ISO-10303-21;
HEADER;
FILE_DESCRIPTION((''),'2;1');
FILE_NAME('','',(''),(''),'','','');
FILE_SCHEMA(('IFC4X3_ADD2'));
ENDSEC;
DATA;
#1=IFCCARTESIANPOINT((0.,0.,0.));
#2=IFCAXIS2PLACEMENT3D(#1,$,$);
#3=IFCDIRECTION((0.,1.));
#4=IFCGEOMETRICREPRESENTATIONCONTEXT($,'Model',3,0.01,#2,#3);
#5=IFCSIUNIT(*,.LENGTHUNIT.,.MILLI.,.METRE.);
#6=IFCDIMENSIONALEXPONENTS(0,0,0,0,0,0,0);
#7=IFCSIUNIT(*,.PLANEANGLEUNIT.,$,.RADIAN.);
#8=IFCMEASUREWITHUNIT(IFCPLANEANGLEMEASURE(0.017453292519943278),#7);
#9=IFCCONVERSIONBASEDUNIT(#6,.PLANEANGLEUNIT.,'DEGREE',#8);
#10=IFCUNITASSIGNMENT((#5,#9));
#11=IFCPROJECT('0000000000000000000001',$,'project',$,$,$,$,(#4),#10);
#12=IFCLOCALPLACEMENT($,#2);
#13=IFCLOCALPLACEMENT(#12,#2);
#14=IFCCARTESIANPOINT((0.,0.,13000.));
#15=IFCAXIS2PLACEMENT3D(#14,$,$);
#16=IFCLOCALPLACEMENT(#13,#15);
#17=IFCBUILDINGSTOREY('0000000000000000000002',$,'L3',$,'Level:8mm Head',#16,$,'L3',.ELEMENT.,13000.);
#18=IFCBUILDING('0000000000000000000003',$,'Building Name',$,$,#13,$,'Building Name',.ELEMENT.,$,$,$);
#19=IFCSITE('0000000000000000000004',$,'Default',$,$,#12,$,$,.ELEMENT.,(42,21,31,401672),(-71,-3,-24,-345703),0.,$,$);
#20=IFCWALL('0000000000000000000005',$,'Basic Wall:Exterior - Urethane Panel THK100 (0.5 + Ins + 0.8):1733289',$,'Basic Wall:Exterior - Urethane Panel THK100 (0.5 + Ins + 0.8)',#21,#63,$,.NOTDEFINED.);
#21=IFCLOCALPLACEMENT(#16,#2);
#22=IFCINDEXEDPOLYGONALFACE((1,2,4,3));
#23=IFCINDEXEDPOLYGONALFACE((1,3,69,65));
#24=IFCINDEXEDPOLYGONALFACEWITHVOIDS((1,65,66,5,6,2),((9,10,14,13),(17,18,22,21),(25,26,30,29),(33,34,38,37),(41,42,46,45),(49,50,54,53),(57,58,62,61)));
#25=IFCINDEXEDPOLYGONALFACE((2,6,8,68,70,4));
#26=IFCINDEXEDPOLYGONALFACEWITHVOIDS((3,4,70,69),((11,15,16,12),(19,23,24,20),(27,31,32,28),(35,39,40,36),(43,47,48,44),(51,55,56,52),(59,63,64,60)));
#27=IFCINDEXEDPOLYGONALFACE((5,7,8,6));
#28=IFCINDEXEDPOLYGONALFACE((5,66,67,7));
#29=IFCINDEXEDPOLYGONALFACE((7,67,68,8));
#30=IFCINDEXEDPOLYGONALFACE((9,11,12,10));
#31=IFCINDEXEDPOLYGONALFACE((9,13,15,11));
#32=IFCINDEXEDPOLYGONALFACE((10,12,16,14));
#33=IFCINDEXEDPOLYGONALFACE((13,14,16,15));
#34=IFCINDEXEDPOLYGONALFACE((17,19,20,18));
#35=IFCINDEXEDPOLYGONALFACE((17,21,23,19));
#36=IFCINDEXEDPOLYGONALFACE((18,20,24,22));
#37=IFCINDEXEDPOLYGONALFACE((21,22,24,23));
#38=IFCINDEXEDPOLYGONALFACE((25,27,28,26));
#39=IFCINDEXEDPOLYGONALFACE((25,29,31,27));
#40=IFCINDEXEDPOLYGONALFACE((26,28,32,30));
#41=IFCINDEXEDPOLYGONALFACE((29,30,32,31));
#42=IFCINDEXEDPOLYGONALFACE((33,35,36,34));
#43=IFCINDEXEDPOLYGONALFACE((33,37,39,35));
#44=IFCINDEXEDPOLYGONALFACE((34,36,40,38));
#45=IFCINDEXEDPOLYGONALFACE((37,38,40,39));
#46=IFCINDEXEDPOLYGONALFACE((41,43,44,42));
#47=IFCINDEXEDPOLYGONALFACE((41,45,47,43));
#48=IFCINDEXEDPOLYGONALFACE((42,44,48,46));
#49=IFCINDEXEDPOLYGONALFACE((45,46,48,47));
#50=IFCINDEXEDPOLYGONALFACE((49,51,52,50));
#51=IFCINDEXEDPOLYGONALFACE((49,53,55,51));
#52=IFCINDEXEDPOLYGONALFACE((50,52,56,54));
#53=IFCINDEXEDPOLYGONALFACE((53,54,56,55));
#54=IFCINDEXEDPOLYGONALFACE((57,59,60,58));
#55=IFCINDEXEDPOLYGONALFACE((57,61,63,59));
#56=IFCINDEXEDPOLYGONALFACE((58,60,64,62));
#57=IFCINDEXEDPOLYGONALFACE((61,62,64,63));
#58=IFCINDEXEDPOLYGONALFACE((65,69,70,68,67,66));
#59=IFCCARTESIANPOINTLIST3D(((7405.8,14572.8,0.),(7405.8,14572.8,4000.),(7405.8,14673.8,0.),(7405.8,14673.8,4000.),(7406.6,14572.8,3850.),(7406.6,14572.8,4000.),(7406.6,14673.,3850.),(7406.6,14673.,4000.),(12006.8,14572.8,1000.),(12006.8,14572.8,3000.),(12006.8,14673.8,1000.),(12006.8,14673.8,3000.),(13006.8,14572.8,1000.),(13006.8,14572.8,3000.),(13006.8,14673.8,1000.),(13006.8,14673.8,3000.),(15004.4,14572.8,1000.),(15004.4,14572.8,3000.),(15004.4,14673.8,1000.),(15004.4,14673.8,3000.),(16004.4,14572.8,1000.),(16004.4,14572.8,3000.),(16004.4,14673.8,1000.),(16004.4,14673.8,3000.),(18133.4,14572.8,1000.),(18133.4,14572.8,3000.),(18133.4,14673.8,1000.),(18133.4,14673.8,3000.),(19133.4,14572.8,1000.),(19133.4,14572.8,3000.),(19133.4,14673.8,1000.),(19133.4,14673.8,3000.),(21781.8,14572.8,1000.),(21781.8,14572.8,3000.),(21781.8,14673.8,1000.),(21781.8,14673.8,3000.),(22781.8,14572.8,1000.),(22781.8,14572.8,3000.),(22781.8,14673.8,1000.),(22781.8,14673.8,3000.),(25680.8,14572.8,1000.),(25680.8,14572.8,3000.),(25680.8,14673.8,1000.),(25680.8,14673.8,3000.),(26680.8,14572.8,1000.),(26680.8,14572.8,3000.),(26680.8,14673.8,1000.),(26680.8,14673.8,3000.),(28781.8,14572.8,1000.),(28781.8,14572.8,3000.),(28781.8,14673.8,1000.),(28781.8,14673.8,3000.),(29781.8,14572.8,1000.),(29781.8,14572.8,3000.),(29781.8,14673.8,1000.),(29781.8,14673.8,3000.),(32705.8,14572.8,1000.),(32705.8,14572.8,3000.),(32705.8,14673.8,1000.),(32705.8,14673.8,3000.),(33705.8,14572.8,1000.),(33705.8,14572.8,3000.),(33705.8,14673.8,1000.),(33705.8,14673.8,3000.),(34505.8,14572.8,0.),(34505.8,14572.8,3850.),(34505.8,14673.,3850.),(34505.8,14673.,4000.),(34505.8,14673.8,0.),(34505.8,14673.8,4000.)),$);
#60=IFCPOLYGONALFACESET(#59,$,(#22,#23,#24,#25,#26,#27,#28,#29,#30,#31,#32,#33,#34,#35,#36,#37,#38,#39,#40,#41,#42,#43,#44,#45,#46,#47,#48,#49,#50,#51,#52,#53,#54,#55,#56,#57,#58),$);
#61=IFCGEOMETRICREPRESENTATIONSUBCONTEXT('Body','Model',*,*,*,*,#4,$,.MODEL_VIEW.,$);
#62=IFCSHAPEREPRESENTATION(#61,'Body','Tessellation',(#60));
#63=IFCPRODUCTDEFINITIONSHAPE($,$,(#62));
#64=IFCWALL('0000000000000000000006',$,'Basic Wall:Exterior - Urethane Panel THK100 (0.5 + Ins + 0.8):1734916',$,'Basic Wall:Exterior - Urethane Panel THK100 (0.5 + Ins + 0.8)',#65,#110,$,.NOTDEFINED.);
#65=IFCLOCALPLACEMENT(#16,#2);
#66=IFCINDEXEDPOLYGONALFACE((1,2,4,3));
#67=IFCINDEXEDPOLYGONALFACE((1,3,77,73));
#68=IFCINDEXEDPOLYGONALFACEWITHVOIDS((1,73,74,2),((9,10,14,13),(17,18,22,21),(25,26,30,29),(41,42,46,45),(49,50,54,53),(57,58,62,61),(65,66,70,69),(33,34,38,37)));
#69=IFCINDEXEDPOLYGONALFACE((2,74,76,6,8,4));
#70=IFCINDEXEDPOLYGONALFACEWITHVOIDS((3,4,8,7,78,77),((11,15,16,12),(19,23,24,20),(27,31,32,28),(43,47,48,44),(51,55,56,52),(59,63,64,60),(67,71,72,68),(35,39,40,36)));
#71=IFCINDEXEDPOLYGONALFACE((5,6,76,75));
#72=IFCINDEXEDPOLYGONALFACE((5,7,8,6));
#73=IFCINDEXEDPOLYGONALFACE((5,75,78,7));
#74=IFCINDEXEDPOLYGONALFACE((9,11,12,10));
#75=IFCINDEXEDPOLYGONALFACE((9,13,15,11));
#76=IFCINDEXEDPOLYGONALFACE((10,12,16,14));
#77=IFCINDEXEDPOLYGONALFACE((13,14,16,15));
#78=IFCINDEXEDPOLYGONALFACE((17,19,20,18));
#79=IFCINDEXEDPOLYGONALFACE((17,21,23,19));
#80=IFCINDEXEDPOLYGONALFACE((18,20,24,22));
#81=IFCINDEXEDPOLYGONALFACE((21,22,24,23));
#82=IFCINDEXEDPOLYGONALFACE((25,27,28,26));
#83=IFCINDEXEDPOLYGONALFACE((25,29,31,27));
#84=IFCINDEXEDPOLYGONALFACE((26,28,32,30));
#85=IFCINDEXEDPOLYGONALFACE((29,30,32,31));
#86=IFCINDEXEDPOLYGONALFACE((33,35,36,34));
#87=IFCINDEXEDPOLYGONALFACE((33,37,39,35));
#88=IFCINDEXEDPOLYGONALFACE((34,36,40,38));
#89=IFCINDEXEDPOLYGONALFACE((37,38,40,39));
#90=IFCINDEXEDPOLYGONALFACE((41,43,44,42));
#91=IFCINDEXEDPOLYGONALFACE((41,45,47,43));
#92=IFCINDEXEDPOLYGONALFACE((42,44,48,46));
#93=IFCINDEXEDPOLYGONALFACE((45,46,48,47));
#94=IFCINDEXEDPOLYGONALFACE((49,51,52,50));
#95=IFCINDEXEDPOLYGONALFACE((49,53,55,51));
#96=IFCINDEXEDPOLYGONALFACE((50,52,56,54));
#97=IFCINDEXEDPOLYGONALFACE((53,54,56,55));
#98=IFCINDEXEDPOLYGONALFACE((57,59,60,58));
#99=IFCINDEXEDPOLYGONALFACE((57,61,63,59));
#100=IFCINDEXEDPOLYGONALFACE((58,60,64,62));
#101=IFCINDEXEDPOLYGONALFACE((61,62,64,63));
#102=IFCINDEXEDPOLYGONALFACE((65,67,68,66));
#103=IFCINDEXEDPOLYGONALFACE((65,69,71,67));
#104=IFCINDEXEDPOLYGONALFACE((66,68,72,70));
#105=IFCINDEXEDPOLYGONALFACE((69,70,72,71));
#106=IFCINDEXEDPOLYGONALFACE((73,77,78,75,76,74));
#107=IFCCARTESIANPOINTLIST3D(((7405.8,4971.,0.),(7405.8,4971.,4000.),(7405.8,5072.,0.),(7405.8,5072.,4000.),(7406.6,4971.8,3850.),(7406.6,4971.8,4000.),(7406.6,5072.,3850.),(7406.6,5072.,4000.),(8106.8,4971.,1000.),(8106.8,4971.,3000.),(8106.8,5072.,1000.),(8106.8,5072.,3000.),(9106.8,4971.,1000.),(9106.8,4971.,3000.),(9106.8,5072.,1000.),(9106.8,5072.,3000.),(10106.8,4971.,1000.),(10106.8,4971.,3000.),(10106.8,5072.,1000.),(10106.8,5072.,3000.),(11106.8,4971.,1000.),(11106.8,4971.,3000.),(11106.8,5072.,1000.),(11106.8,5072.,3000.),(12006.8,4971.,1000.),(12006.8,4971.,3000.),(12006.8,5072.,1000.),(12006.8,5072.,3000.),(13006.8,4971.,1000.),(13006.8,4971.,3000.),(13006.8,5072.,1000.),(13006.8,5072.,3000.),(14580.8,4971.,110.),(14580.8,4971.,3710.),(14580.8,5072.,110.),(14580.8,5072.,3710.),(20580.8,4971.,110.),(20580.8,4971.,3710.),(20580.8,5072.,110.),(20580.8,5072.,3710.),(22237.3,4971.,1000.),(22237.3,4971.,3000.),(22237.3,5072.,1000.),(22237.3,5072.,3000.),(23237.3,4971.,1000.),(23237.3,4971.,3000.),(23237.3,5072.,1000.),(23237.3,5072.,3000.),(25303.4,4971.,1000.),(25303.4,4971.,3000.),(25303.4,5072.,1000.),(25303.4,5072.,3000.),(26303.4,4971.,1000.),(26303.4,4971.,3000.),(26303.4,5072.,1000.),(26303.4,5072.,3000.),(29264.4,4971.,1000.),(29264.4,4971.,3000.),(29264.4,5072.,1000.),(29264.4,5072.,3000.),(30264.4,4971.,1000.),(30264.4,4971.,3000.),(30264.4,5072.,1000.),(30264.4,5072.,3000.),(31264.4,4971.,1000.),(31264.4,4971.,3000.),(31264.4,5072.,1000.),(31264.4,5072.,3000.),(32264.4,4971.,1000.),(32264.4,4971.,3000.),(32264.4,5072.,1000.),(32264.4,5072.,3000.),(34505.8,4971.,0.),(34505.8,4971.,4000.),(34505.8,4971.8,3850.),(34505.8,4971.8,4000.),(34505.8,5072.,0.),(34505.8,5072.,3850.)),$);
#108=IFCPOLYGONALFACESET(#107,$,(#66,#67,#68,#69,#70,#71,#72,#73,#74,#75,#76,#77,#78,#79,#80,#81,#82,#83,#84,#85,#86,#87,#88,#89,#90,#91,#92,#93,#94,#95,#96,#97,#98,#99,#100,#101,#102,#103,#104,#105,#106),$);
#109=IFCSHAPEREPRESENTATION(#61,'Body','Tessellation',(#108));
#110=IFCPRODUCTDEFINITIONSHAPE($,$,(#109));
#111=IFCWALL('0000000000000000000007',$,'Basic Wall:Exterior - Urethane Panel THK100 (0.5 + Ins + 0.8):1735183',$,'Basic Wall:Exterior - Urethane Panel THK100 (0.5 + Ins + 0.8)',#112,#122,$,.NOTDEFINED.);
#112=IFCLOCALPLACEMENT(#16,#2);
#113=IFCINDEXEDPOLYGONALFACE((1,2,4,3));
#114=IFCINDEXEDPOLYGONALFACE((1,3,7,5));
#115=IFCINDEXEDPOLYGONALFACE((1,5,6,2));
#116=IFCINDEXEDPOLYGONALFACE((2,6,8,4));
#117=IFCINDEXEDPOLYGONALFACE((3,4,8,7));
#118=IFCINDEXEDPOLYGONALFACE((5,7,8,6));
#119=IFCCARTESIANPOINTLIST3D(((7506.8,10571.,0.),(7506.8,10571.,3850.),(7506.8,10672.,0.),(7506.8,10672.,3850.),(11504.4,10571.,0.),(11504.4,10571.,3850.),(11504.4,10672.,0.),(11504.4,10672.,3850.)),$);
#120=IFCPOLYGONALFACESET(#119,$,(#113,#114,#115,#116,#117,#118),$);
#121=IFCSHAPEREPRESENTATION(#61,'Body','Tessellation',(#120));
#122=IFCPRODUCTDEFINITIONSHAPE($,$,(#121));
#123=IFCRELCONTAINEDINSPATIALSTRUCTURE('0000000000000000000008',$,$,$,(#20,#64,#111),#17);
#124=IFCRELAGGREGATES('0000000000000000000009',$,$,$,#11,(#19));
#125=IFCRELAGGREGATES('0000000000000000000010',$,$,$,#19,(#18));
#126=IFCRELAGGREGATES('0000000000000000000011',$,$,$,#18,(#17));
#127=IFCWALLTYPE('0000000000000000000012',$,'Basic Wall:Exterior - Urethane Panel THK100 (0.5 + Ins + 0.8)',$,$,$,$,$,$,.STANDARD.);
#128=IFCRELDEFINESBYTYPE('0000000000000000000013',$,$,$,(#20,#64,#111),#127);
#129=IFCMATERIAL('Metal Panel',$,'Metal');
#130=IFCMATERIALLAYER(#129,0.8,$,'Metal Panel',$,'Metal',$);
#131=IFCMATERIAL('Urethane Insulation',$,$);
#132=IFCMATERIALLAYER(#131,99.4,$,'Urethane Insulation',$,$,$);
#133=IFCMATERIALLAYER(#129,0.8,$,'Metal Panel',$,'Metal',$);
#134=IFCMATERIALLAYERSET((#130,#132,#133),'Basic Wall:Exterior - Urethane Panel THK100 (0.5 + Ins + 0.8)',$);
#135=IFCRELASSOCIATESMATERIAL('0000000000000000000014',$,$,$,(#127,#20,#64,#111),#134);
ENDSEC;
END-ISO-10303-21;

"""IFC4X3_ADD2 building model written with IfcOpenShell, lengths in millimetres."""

from ifc_helpers import new_model, entity, si_unit, converted_unit, direction, frame, frame_2d, origin, place, context, subcontext, project, spatial, polyline, rectangle, extrude, clip, bounded_halfspace, material, layer, layer_set, type_object, element, save


model = new_model("IFC4X3_ADD2")

# Units and contexts
model_context = context("Model", 3, precision=0.01, world=origin(), true_north=direction((0.0, 1.0)))
body_context = subcontext(model_context, "Body", "Model", "MODEL_VIEW")
ifc_project = project(units=[si_unit("LENGTHUNIT", "METRE", prefix="MILLI"), converted_unit("PLANEANGLEUNIT", "DEGREE", entity("IfcPlaneAngleMeasure", 0.017453292519943278), si_unit("PLANEANGLEUNIT", "RADIAN"), dimensions=[0, 0, 0, 0, 0, 0, 0])], contexts=[model_context])

# Site, building, storey
site_placement = place(None, origin())
site = spatial("IfcSite", under=ifc_project, at=site_placement, Name="Default", CompositionType="ELEMENT", RefLatitude=(42, 21, 31, 401672), RefLongitude=(-71, -3, -24, -345703), RefElevation=0.0)
building_placement = place(site_placement, origin())
building = spatial("IfcBuilding", under=site, at=building_placement, Name="Building Name", LongName="Building Name", CompositionType="ELEMENT")
storey_placement = place(building_placement, frame((0.0, 0.0, 13000.0)))
storey = spatial("IfcBuildingStorey", under=building, at=storey_placement, Name="L3", ObjectType="Level:8mm Head", LongName="L3", CompositionType="ELEMENT", Elevation=13000.0)

# Walls, openings
ifc_material_1 = material(Name="Metal Panel", Category="Metal")
ifc_layer_1 = layer(ifc_material_1, 0.8, Name="Metal Panel", Category="Metal")
ifc_material_2 = material(Name="Urethane Insulation")
ifc_layer_2 = layer(ifc_material_2, 99.4, Name="Urethane Insulation")
ifc_layer_3 = layer(ifc_material_1, 0.8, Name="Metal Panel", Category="Metal")
ifc_layer_set_1 = layer_set([ifc_layer_1, ifc_layer_2, ifc_layer_3], Name="Basic Wall:Exterior - Urethane Panel THK100 (0.5 + Ins + 0.8)")
wall_type = type_object("IfcWallType", Name="Basic Wall:Exterior - Urethane Panel THK100 (0.5 + Ins + 0.8)", PredefinedType="STANDARD", material=ifc_layer_set_1)
wall_1_placement = place(storey_placement, frame((7405.8, 14623.3, 0.0)))
wall_1 = element("IfcWall", 1, at=wall_1_placement, inside=storey, type_object=wall_type, material=ifc_layer_set_1, Name="Basic Wall:Exterior - Urethane Panel THK100 (0.5 + Ins + 0.8):1733289", ObjectType="Basic Wall:Exterior - Urethane Panel THK100 (0.5 + Ins + 0.8)", PredefinedType="NOTDEFINED", context=body_context, shape_type="Clipping", body=[
    clip(extrude(rectangle(XDim=27100.0, YDim=101.0, at=frame_2d((13550.0, 0.0), x_axis=(-1.0, 0.0))), origin(), (0.0, 0.0, 1.0), 4000.0), bounded_halfspace(frame((0.8, -50.5, 3850.0), z_axis=(0.0, 0.0, -1.0), x_axis=(0.0, 1.0, 0.0)), True, frame((0.8, -50.5, 3850.0)), polyline([(0.0, 0.0), (100.2, 0.0), (3996.8, 0.0), (4097.8, 0.0), (6496.8, 0.0), (6597.8, 0.0), (10046.8, 0.0), (10147.8, 0.0), (11946.8, 0.0), (12047.8, 0.0), (13631.8, 0.0), (13732.8, 0.0), (20596.8, 0.0), (20697.8, 0.0), (27099.2, 0.0), (27099.2, 100.2), (0.0, 100.2), (0.0, 0.0)]))),
])
opening_1_placement = place(wall_1_placement, frame((10727.6, -50.5, 1000.0)))
element("IfcOpeningElement", 2, at=opening_1_placement, cuts=wall_1, PredefinedType="OPENING", context=body_context, shape_type="SweptSolid", body=[
    extrude(rectangle(XDim=2000.0, YDim=1000.0, at=frame_2d((1000.0, 500.0), x_axis=(-1.0, 0.0))), frame((0.0, 0.0, 0.0), z_axis=(0.0, 1.0, 0.0), x_axis=(0.0, 0.0, 1.0)), (0.0, 0.0, 1.0), 101.0),
])
opening_2_placement = place(wall_1_placement, frame((7598.6, -50.5, 1000.0)))
element("IfcOpeningElement", 3, at=opening_2_placement, cuts=wall_1, PredefinedType="OPENING", context=body_context, shape_type="SweptSolid", body=[
    extrude(rectangle(XDim=2000.0, YDim=1000.0, at=frame_2d((1000.0, 500.0), x_axis=(-1.0, 0.0))), frame((0.0, 0.0, 0.0), z_axis=(0.0, 1.0, 0.0), x_axis=(0.0, 0.0, 1.0)), (0.0, 0.0, 1.0), 101.0),
])
opening_3_placement = place(wall_1_placement, frame((4601.0, -50.5, 1000.0)))
element("IfcOpeningElement", 4, at=opening_3_placement, cuts=wall_1, PredefinedType="OPENING", context=body_context, shape_type="SweptSolid", body=[
    extrude(rectangle(XDim=2000.0, YDim=1000.0, at=frame_2d((1000.0, 500.0), x_axis=(-1.0, 0.0))), frame((0.0, 0.0, 0.0), z_axis=(0.0, 1.0, 0.0), x_axis=(0.0, 0.0, 1.0)), (0.0, 0.0, 1.0), 101.0),
])
opening_4_placement = place(wall_1_placement, frame((14376.0, -50.5, 1000.0)))
element("IfcOpeningElement", 5, at=opening_4_placement, cuts=wall_1, PredefinedType="OPENING", context=body_context, shape_type="SweptSolid", body=[
    extrude(rectangle(XDim=2000.0, YDim=1000.0, at=frame_2d((1000.0, 500.0), x_axis=(-1.0, 0.0))), frame((0.0, 0.0, 0.0), z_axis=(0.0, 1.0, 0.0), x_axis=(0.0, 0.0, 1.0)), (0.0, 0.0, 1.0), 101.0),
])
opening_5_placement = place(wall_1_placement, frame((18275.0, -50.5, 1000.0)))
element("IfcOpeningElement", 6, at=opening_5_placement, cuts=wall_1, PredefinedType="OPENING", context=body_context, shape_type="SweptSolid", body=[
    extrude(rectangle(XDim=2000.0, YDim=1000.0, at=frame_2d((1000.0, 500.0), x_axis=(-1.0, 0.0))), frame((0.0, 0.0, 0.0), z_axis=(0.0, 1.0, 0.0), x_axis=(0.0, 0.0, 1.0)), (0.0, 0.0, 1.0), 101.0),
])
opening_6_placement = place(wall_1_placement, frame((21376.0, -50.5, 1000.0)))
element("IfcOpeningElement", 7, at=opening_6_placement, cuts=wall_1, PredefinedType="OPENING", context=body_context, shape_type="SweptSolid", body=[
    extrude(rectangle(XDim=2000.0, YDim=1000.0, at=frame_2d((1000.0, 500.0), x_axis=(-1.0, 0.0))), frame((0.0, 0.0, 0.0), z_axis=(0.0, 1.0, 0.0), x_axis=(0.0, 0.0, 1.0)), (0.0, 0.0, 1.0), 101.0),
])
opening_7_placement = place(wall_1_placement, frame((25300.0, -50.5, 1000.0)))
element("IfcOpeningElement", 8, at=opening_7_placement, cuts=wall_1, PredefinedType="OPENING", context=body_context, shape_type="SweptSolid", body=[
    extrude(rectangle(XDim=2000.0, YDim=1000.0, at=frame_2d((1000.0, 500.0), x_axis=(-1.0, 0.0))), frame((0.0, 0.0, 0.0), z_axis=(0.0, 1.0, 0.0), x_axis=(0.0, 0.0, 1.0)), (0.0, 0.0, 1.0), 101.0),
])
wall_2_placement = place(storey_placement, frame((7405.8, 5021.5, 0.0)))
wall_2 = element("IfcWall", 9, at=wall_2_placement, inside=storey, type_object=wall_type, material=ifc_layer_set_1, Name="Basic Wall:Exterior - Urethane Panel THK100 (0.5 + Ins + 0.8):1734916", ObjectType="Basic Wall:Exterior - Urethane Panel THK100 (0.5 + Ins + 0.8)", PredefinedType="NOTDEFINED", context=body_context, shape_type="Clipping", body=[
    clip(extrude(rectangle(XDim=27100.0, YDim=101.0, at=frame_2d((13550.0, 0.0), x_axis=(-1.0, 0.0))), origin(), (0.0, 0.0, 1.0), 4000.0), bounded_halfspace(frame((27100.0, -49.7, 3850.0), z_axis=(0.0, 0.0, -1.0), x_axis=(0.0, 1.0, 0.0)), True, frame((27100.0, -49.7, 3850.0)), polyline([(0.0, 0.0), (0.0, 100.2), (-6401.4, 100.2), (-6502.4, 100.2), (-13381.5, 100.2), (-13482.5, 100.2), (-20501.4, 100.2), (-20602.4, 100.2), (-26999.0, 100.2), (-27099.2, 100.2), (-27099.2, 0.0), (0.0, 0.0)]))),
])
opening_8_placement = place(wall_2_placement, frame((13175.0, 50.5, 110.0)))
element("IfcOpeningElement", 10, at=opening_8_placement, cuts=wall_2, PredefinedType="OPENING", context=body_context, shape_type="SweptSolid", body=[
    extrude(rectangle(XDim=3600.0, YDim=6000.0, at=frame_2d((1800.0, 3000.0), x_axis=(-1.0, 0.0))), frame((0.0, 0.0, 0.0), z_axis=(0.0, -1.0, 0.0), x_axis=(0.0, 0.0, 1.0)), (0.0, 0.0, 1.0), 101.0),
])
opening_9_placement = place(wall_2_placement, frame((24858.6, 50.5, 1000.0)))
element("IfcOpeningElement", 11, at=opening_9_placement, cuts=wall_2, PredefinedType="OPENING", context=body_context, shape_type="SweptSolid", body=[
    extrude(rectangle(XDim=2000.0, YDim=1000.0, at=frame_2d((1000.0, 500.0), x_axis=(-1.0, 0.0))), frame((0.0, 0.0, 0.0), z_axis=(0.0, -1.0, 0.0), x_axis=(0.0, 0.0, 1.0)), (0.0, 0.0, 1.0), 101.0),
])
opening_10_placement = place(wall_2_placement, frame((22858.6, 50.5, 1000.0)))
element("IfcOpeningElement", 12, at=opening_10_placement, cuts=wall_2, PredefinedType="OPENING", context=body_context, shape_type="SweptSolid", body=[
    extrude(rectangle(XDim=2000.0, YDim=1000.0, at=frame_2d((1000.0, 500.0), x_axis=(-1.0, 0.0))), frame((0.0, 0.0, 0.0), z_axis=(0.0, -1.0, 0.0), x_axis=(0.0, 0.0, 1.0)), (0.0, 0.0, 1.0), 101.0),
])
opening_11_placement = place(wall_2_placement, frame((18897.6, 50.5, 1000.0)))
element("IfcOpeningElement", 13, at=opening_11_placement, cuts=wall_2, PredefinedType="OPENING", context=body_context, shape_type="SweptSolid", body=[
    extrude(rectangle(XDim=2000.0, YDim=1000.0, at=frame_2d((1000.0, 500.0), x_axis=(-1.0, 0.0))), frame((0.0, 0.0, 0.0), z_axis=(0.0, -1.0, 0.0), x_axis=(0.0, 0.0, 1.0)), (0.0, 0.0, 1.0), 101.0),
])
opening_12_placement = place(wall_2_placement, frame((15831.5, 50.5, 1000.0)))
element("IfcOpeningElement", 14, at=opening_12_placement, cuts=wall_2, PredefinedType="OPENING", context=body_context, shape_type="SweptSolid", body=[
    extrude(rectangle(XDim=2000.0, YDim=1000.0, at=frame_2d((1000.0, 500.0), x_axis=(-1.0, 0.0))), frame((0.0, 0.0, 0.0), z_axis=(0.0, -1.0, 0.0), x_axis=(0.0, 0.0, 1.0)), (0.0, 0.0, 1.0), 101.0),
])
opening_13_placement = place(wall_2_placement, frame((1701.0, 50.5, 1000.0)))
element("IfcOpeningElement", 15, at=opening_13_placement, cuts=wall_2, PredefinedType="OPENING", context=body_context, shape_type="SweptSolid", body=[
    extrude(rectangle(XDim=2000.0, YDim=1000.0, at=frame_2d((1000.0, 500.0), x_axis=(-1.0, 0.0))), frame((0.0, 0.0, 0.0), z_axis=(0.0, -1.0, 0.0), x_axis=(0.0, 0.0, 1.0)), (0.0, 0.0, 1.0), 101.0),
])
opening_14_placement = place(wall_2_placement, frame((3701.0, 50.5, 1000.0)))
element("IfcOpeningElement", 16, at=opening_14_placement, cuts=wall_2, PredefinedType="OPENING", context=body_context, shape_type="SweptSolid", body=[
    extrude(rectangle(XDim=2000.0, YDim=1000.0, at=frame_2d((1000.0, 500.0), x_axis=(-1.0, 0.0))), frame((0.0, 0.0, 0.0), z_axis=(0.0, -1.0, 0.0), x_axis=(0.0, 0.0, 1.0)), (0.0, 0.0, 1.0), 101.0),
])
opening_15_placement = place(wall_2_placement, frame((5601.0, 50.5, 1000.0)))
element("IfcOpeningElement", 17, at=opening_15_placement, cuts=wall_2, PredefinedType="OPENING", context=body_context, shape_type="SweptSolid", body=[
    extrude(rectangle(XDim=2000.0, YDim=1000.0, at=frame_2d((1000.0, 500.0), x_axis=(-1.0, 0.0))), frame((0.0, 0.0, 0.0), z_axis=(0.0, -1.0, 0.0), x_axis=(0.0, 0.0, 1.0)), (0.0, 0.0, 1.0), 101.0),
])

# Wall
wall_3_placement = place(storey_placement, frame((7506.8, 10621.5, 0.0)))
element("IfcWall", 18, at=wall_3_placement, inside=storey, type_object=wall_type, material=ifc_layer_set_1, Name="Basic Wall:Exterior - Urethane Panel THK100 (0.5 + Ins + 0.8):1735183", ObjectType="Basic Wall:Exterior - Urethane Panel THK100 (0.5 + Ins + 0.8)", PredefinedType="NOTDEFINED", context=body_context, shape_type="Clipping", body=[
    clip(extrude(rectangle(XDim=3997.6, YDim=101.0, at=frame_2d((1998.8, 0.0), x_axis=(-1.0, 0.0))), origin(), (0.0, 0.0, 1.0), 3850.0), bounded_halfspace(frame((0.0, -50.5, 3850.0), z_axis=(0.0, 0.0, -1.0), x_axis=(0.0, 1.0, 0.0)), True, frame((0.0, -50.5, 3850.0)), polyline([(0.0, 0.0), (3997.6, 0.0), (3997.6, 101.0), (3896.6, 101.0), (0.0, 101.0), (0.0, 0.0)]))),
])

save(model, "model.ifc")
